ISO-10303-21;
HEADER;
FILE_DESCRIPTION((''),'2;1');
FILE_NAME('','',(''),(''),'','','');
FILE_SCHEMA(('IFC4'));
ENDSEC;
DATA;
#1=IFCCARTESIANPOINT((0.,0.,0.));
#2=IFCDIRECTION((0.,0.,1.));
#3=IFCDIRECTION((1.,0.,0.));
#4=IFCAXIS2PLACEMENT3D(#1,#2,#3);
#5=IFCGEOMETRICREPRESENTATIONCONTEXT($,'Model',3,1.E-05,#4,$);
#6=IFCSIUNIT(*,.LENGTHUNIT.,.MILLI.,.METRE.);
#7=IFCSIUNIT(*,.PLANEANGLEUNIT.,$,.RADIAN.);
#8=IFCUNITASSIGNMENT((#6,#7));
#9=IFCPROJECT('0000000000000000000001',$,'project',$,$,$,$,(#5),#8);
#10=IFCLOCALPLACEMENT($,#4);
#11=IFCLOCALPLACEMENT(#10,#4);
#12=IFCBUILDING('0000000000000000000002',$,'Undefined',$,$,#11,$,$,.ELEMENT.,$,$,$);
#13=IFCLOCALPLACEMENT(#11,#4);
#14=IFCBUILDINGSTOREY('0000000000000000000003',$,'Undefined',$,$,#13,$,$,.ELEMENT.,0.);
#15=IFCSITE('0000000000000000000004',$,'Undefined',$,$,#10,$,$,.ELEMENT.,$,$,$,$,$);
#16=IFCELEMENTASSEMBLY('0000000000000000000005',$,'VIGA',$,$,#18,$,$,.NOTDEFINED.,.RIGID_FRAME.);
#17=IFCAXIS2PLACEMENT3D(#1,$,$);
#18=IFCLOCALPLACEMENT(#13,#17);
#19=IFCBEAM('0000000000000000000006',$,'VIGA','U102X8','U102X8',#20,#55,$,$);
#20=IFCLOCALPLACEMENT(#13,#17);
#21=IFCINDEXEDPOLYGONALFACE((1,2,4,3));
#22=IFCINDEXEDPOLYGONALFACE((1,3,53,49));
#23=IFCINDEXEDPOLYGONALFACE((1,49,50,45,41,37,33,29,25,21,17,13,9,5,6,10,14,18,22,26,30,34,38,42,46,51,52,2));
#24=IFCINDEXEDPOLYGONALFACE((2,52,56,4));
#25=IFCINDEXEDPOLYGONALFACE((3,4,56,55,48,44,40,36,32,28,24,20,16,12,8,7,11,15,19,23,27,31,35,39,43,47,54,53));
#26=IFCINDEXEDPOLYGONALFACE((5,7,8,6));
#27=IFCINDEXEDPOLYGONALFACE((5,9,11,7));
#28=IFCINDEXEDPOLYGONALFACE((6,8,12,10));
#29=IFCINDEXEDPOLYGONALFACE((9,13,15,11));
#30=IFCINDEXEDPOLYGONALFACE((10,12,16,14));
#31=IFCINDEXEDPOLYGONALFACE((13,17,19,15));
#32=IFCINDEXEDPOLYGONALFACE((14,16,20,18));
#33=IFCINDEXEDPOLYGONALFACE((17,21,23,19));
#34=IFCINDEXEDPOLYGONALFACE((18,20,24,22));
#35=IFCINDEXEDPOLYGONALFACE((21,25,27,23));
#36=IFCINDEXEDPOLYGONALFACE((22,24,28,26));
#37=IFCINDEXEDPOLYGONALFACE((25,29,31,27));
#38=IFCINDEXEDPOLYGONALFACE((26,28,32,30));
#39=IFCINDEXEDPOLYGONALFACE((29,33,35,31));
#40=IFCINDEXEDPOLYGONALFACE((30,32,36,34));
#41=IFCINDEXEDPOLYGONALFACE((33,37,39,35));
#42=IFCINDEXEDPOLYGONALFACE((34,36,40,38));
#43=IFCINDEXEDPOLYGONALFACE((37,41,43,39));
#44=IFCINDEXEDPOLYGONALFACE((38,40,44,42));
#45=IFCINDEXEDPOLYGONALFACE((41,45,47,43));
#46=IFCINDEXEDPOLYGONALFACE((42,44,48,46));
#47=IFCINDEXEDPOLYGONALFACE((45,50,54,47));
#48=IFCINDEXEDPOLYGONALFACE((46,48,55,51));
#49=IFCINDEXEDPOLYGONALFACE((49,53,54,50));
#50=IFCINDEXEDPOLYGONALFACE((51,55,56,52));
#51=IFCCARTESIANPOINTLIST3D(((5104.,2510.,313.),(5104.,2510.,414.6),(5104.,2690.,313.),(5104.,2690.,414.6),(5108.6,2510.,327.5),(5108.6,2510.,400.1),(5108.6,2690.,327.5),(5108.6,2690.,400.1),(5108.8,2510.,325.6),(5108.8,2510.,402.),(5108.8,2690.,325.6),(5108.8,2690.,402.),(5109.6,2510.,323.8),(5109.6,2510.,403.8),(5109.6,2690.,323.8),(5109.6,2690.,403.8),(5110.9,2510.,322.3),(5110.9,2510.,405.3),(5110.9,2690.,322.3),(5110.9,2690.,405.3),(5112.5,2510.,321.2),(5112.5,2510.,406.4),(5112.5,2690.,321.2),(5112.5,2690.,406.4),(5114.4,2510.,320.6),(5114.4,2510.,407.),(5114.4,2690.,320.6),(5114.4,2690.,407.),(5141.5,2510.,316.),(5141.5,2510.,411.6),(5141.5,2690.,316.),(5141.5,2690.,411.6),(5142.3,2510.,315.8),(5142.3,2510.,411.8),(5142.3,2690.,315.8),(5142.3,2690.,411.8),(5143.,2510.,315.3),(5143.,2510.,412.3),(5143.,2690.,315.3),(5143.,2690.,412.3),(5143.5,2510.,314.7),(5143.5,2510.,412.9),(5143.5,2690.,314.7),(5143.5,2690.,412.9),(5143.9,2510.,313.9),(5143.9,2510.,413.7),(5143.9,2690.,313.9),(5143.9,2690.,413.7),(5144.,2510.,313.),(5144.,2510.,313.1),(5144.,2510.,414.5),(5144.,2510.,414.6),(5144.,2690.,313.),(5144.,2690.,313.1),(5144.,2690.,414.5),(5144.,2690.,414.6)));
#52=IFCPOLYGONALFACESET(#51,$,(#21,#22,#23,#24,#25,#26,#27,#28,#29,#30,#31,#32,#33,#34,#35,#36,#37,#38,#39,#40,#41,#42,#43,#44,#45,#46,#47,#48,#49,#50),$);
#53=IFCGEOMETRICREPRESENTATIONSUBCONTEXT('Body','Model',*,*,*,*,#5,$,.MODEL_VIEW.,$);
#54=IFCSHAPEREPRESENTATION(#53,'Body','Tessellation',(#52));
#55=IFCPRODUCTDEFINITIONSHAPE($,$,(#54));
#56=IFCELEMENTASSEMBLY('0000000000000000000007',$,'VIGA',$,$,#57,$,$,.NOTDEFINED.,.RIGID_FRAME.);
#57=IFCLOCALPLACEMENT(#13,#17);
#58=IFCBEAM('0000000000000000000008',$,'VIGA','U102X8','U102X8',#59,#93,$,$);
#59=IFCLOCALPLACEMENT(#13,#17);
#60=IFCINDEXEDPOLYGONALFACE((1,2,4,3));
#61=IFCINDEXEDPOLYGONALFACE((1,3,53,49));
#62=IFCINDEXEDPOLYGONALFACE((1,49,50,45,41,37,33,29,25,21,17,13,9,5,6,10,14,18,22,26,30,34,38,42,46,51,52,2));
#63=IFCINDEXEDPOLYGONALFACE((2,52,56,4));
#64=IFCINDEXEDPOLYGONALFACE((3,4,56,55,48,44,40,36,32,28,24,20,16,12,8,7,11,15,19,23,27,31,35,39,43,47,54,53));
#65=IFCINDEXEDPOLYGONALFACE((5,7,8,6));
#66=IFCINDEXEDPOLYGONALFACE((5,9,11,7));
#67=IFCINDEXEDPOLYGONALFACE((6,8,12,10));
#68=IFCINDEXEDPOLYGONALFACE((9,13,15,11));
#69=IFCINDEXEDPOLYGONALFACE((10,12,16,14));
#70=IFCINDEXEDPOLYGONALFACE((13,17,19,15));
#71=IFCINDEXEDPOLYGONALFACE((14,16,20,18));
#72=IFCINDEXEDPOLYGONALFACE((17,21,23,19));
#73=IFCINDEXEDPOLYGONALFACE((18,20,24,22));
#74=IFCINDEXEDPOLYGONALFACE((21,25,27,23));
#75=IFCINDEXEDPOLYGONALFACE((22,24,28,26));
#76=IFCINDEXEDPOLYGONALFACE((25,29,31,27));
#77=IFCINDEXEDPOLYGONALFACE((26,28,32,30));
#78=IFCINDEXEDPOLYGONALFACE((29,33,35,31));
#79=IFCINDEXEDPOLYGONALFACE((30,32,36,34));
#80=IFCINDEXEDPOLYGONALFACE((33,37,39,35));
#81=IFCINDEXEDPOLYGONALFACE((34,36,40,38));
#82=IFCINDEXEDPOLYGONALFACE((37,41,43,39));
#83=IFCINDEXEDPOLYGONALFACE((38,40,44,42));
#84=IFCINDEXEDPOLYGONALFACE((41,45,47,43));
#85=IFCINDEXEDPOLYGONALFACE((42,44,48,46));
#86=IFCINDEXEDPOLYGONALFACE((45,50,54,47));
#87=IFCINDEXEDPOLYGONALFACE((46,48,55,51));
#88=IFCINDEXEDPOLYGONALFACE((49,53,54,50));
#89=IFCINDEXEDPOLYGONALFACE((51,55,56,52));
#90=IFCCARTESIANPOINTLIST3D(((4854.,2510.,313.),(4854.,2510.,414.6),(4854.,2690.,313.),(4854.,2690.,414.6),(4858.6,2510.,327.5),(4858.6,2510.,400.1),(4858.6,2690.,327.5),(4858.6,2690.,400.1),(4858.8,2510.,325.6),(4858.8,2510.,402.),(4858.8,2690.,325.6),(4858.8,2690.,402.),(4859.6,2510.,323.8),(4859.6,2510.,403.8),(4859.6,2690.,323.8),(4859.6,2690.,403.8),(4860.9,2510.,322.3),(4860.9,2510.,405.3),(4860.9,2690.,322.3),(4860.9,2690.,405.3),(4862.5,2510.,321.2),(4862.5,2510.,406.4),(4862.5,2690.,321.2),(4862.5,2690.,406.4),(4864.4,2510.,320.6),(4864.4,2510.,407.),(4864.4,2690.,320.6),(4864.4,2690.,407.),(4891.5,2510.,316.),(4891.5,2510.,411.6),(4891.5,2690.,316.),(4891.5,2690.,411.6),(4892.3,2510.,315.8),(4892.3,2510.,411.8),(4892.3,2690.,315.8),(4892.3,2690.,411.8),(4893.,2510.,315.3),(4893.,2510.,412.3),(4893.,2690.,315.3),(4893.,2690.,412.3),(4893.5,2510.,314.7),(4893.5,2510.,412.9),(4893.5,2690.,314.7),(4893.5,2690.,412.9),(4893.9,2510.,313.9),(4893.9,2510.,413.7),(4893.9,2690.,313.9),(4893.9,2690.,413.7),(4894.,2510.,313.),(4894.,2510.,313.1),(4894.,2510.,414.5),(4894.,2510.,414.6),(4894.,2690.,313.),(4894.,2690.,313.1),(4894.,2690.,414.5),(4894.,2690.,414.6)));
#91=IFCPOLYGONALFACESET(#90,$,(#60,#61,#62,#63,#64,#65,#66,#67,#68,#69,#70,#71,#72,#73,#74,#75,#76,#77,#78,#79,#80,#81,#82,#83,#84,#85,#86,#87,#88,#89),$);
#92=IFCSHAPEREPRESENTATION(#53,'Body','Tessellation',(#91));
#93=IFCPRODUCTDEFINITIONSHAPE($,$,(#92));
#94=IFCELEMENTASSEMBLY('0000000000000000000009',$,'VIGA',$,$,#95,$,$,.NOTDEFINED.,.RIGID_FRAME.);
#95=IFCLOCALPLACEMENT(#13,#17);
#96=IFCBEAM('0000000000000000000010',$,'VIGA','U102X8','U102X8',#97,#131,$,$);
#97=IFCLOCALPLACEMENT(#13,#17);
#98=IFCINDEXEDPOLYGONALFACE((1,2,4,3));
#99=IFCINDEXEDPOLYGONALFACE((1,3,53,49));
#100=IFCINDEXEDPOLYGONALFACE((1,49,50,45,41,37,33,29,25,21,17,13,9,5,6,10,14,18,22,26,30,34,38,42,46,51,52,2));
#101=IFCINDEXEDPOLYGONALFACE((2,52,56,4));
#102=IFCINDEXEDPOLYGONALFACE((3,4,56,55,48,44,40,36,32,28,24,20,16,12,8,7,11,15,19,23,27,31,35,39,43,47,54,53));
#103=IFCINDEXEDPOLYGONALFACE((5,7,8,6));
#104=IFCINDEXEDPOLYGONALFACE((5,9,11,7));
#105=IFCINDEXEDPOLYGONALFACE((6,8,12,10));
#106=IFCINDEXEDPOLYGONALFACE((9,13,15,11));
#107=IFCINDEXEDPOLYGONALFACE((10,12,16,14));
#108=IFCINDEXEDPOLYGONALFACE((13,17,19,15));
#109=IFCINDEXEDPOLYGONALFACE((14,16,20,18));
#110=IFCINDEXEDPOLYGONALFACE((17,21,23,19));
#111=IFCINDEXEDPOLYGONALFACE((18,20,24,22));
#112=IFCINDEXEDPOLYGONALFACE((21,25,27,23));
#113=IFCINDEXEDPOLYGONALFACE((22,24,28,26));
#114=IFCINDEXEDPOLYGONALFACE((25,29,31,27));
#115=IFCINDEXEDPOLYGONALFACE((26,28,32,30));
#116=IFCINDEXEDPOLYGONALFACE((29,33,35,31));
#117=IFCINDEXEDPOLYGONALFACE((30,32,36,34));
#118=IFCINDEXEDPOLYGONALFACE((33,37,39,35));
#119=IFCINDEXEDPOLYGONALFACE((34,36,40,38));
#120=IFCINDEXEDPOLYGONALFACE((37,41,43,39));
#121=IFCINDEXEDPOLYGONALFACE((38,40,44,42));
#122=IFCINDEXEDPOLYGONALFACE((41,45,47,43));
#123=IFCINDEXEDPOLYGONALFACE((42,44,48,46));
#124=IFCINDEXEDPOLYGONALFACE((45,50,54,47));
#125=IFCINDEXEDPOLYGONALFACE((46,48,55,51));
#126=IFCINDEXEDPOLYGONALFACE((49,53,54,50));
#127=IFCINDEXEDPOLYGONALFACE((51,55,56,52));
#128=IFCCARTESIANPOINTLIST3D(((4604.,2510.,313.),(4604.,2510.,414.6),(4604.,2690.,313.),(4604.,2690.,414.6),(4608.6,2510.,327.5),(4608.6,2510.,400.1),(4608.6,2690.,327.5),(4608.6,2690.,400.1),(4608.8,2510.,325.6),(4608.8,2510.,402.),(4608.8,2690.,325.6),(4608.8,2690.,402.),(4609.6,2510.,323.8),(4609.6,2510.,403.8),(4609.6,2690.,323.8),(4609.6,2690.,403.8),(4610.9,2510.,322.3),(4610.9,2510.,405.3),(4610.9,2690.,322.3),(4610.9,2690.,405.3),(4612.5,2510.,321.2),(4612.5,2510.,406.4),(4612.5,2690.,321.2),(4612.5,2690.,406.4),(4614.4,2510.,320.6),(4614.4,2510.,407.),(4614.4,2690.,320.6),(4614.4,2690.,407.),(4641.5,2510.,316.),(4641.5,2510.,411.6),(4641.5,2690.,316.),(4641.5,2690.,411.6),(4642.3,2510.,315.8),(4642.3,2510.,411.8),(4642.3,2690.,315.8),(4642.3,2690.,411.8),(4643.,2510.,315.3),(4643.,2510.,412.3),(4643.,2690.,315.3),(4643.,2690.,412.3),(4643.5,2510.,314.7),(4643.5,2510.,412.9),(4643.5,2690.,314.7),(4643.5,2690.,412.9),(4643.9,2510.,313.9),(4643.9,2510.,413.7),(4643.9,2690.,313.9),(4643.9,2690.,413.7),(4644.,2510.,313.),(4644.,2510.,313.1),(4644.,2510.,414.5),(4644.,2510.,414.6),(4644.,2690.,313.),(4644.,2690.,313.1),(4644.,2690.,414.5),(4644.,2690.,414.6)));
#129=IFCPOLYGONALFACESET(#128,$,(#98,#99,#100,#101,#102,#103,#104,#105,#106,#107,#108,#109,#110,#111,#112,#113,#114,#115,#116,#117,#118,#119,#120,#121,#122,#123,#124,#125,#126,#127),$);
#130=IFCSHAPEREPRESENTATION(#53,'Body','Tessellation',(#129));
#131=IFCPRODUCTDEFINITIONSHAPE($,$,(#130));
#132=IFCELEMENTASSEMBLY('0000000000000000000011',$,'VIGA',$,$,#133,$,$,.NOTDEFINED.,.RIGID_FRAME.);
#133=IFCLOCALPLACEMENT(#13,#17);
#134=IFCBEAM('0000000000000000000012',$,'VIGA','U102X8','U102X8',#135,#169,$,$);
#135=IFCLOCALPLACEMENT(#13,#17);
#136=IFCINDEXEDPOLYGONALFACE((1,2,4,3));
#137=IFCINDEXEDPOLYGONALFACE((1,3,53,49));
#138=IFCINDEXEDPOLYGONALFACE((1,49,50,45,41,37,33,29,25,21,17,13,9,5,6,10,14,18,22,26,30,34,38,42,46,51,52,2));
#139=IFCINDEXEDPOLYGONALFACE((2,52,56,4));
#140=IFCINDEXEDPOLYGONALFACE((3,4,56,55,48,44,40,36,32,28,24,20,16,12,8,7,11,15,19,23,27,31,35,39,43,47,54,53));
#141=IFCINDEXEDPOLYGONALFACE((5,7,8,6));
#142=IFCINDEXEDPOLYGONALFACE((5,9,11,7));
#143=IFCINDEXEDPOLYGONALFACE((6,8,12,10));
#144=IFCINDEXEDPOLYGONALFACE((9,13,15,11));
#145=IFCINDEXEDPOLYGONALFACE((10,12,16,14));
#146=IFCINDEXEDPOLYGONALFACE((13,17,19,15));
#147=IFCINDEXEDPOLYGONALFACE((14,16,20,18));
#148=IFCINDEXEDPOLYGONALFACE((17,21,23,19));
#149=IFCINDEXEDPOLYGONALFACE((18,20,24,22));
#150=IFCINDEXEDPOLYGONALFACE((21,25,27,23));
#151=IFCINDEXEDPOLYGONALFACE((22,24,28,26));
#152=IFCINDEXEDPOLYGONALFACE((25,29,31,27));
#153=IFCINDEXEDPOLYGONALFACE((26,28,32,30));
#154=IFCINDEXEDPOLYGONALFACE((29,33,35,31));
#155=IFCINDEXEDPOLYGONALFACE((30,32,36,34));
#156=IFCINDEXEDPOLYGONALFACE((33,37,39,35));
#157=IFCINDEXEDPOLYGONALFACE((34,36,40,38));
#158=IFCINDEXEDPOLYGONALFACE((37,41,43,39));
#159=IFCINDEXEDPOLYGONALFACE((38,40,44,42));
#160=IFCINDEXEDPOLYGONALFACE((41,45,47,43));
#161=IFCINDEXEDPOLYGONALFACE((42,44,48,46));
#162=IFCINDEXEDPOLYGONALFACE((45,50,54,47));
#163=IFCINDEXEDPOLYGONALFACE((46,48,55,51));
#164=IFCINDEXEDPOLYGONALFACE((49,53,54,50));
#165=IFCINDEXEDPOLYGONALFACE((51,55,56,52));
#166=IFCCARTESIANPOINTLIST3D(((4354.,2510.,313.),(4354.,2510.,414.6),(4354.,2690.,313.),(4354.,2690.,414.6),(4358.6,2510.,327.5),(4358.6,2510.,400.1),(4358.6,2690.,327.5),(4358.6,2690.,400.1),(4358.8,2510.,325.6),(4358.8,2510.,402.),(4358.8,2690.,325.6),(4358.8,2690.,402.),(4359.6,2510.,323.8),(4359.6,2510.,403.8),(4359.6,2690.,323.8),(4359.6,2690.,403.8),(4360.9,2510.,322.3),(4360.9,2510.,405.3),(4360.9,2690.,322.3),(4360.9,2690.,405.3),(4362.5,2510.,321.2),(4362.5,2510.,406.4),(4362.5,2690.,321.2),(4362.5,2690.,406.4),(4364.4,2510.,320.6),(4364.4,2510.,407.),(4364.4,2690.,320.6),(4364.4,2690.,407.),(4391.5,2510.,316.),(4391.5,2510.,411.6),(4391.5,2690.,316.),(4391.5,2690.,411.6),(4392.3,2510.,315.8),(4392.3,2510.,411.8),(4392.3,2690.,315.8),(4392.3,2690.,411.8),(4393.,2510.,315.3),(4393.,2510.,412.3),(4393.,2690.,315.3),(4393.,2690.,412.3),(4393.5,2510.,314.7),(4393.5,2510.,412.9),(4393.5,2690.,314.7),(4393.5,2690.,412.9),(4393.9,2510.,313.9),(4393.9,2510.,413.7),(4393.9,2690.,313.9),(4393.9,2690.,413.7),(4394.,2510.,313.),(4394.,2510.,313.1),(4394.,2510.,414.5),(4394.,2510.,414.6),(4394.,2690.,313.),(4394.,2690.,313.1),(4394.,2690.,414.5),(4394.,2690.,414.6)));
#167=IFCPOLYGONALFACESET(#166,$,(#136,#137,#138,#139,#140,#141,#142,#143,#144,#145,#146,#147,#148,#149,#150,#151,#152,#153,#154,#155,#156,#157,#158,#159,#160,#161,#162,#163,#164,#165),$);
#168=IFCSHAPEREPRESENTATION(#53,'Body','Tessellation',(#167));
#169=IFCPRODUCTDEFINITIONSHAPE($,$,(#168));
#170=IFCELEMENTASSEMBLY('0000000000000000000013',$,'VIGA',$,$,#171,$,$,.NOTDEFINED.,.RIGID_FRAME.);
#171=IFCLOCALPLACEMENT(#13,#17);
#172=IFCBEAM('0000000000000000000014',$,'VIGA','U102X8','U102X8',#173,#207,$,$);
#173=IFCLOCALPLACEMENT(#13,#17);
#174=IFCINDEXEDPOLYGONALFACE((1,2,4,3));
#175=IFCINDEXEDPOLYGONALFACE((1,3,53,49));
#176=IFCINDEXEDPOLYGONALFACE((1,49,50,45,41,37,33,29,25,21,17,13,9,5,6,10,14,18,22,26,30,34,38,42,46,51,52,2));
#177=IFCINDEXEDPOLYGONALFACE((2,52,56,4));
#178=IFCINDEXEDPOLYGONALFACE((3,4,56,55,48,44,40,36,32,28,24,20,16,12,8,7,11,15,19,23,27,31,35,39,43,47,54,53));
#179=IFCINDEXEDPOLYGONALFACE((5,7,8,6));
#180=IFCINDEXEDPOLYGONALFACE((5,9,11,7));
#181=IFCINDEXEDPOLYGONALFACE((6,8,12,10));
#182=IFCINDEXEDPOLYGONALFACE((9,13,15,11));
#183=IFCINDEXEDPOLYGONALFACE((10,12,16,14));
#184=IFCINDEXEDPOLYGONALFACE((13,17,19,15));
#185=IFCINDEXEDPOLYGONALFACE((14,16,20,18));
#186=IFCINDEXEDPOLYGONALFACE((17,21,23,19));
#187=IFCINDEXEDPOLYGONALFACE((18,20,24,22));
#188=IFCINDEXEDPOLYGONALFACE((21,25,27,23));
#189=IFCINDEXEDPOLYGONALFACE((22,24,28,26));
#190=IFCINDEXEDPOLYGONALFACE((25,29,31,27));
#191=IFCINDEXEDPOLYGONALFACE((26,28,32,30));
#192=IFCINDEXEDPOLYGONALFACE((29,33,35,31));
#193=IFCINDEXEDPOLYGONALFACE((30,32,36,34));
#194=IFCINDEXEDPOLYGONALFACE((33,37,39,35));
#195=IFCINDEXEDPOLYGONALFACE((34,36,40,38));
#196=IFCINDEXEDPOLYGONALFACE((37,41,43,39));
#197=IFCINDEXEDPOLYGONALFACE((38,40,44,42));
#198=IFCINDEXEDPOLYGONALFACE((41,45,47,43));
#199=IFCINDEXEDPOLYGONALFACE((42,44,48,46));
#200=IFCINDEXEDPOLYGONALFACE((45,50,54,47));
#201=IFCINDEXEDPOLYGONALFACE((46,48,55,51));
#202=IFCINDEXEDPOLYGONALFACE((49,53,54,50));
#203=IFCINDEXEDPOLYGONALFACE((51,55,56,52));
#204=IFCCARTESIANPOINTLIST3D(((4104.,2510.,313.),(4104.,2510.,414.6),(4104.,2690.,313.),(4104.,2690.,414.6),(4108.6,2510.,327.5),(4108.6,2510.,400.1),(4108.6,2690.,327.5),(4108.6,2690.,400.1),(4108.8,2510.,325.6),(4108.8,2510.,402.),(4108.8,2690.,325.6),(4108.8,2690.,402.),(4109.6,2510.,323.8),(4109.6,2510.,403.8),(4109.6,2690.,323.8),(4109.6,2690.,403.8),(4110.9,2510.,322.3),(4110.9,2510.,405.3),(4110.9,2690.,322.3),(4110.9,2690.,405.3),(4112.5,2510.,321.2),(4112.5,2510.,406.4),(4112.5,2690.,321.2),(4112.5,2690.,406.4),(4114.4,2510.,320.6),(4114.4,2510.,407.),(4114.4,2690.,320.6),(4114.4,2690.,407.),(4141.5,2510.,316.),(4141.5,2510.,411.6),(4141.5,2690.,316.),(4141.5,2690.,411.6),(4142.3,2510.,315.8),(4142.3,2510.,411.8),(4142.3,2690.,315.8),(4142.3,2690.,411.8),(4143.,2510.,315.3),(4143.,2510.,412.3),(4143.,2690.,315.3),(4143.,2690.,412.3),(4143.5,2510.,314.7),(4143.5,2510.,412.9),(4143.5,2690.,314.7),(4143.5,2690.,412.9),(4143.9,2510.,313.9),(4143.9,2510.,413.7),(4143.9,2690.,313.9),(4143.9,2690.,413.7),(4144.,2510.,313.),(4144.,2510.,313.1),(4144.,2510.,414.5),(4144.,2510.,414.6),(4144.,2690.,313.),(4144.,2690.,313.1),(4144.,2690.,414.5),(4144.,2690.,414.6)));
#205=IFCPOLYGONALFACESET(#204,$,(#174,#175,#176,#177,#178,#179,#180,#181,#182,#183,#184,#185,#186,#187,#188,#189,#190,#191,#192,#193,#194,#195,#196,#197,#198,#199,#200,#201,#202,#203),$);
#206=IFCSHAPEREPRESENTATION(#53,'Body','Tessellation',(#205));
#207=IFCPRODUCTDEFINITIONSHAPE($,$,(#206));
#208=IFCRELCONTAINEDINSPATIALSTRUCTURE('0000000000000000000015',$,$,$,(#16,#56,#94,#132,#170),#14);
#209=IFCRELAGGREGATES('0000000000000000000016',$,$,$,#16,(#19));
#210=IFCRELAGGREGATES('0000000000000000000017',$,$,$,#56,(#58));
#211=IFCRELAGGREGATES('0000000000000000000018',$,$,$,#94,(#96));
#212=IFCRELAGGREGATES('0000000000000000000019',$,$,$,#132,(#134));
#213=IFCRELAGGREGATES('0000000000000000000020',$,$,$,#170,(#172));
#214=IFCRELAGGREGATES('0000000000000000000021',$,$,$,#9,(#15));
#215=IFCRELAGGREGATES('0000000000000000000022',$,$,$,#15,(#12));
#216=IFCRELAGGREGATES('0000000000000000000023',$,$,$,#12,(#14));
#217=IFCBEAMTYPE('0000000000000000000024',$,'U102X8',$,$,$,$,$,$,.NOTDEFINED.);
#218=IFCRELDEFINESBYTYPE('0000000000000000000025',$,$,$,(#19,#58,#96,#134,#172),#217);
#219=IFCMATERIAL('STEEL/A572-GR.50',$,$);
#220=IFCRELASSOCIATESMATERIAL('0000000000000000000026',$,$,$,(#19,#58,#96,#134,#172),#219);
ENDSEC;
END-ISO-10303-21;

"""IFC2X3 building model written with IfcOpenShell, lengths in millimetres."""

from ifc_helpers import new_model, si_unit, frame, origin_with_axes, origin_2d_with_axis, place, context, subcontext, project, spatial, u_section, extrude, material, type_object, element, aggregate, save


model = new_model("IFC2X3")

# Units and contexts
model_context = context("Model", 3, precision=1e-05, world=origin_with_axes())
body_context = subcontext(model_context, "Body", "Model", "MODEL_VIEW")
ifc_project = project(units=[si_unit("LENGTHUNIT", "METRE", prefix="MILLI"), si_unit("PLANEANGLEUNIT", "RADIAN")], contexts=[model_context])

# Site, building, storey
site_placement = place(None, origin_with_axes())
site = spatial("IfcSite", under=ifc_project, at=site_placement, Name="Undefined", CompositionType="ELEMENT")
building_placement = place(site_placement, origin_with_axes())
building = spatial("IfcBuilding", under=site, at=building_placement, Name="Undefined", CompositionType="ELEMENT")
storey_placement = place(building_placement, origin_with_axes())
storey = spatial("IfcBuildingStorey", under=building, at=storey_placement, Name="Undefined", CompositionType="ELEMENT", Elevation=0.0)

# Element assemblies, beams
ifc_material_1 = material(Name="STEEL/A572-GR.50")
beam_type_1 = type_object("IfcBeamType", Name="U102X8", PredefinedType="NOTDEFINED")
assembly_1_placement = place(storey_placement, origin_with_axes())
assembly_1 = element("IfcElementAssembly", 1, at=assembly_1_placement, inside=storey, Name="VIGA", AssemblyPlace="NOTDEFINED", PredefinedType="RIGID_FRAME")
beam_1_placement = place(assembly_1_placement, frame((5124.0, 2510.0, 363.8), z_axis=(0.0, 0.0, 1.0), x_axis=(0.0, 1.0, 0.0)))
beam_1 = element("IfcBeam", 2, at=beam_1_placement, type_object=beam_type_1, material=ifc_material_1, Name="VIGA", Description="U102X8", ObjectType="U102X8", context=body_context, shape_type="SweptSolid", body=[
    extrude(u_section(Depth=101.6, FlangeWidth=40.0, WebThickness=4.6, FlangeThickness=6.0, FilletRadius=7.0, EdgeRadius=3.0, FlangeSlope=0.16839, at=origin_2d_with_axis()), frame((180.0, 0.0, 0.0), z_axis=(-1.0, 0.0, 0.0), x_axis=(0.0, -1.0, 0.0)), (0.0, 0.0, 1.0), 180.0),
])
aggregate(assembly_1, [beam_1])
assembly_2_placement = place(storey_placement, origin_with_axes())
assembly_2 = element("IfcElementAssembly", 3, at=assembly_2_placement, inside=storey, Name="VIGA", AssemblyPlace="NOTDEFINED", PredefinedType="RIGID_FRAME")
beam_2_placement = place(assembly_2_placement, frame((4874.0, 2510.0, 363.8), z_axis=(0.0, 0.0, 1.0), x_axis=(0.0, 1.0, 0.0)))
beam_2 = element("IfcBeam", 4, at=beam_2_placement, type_object=beam_type_1, material=ifc_material_1, Name="VIGA", Description="U102X8", ObjectType="U102X8", context=body_context, shape_type="SweptSolid", body=[
    extrude(u_section(Depth=101.6, FlangeWidth=40.0, WebThickness=4.6, FlangeThickness=6.0, FilletRadius=7.0, EdgeRadius=3.0, FlangeSlope=0.16839, at=origin_2d_with_axis()), frame((180.0, 0.0, 0.0), z_axis=(-1.0, 0.0, 0.0), x_axis=(0.0, -1.0, 0.0)), (0.0, 0.0, 1.0), 180.0),
])
aggregate(assembly_2, [beam_2])
assembly_3_placement = place(storey_placement, origin_with_axes())
assembly_3 = element("IfcElementAssembly", 5, at=assembly_3_placement, inside=storey, Name="VIGA", AssemblyPlace="NOTDEFINED", PredefinedType="RIGID_FRAME")
beam_3_placement = place(assembly_3_placement, frame((4624.0, 2510.0, 363.8), z_axis=(0.0, 0.0, 1.0), x_axis=(0.0, 1.0, 0.0)))
beam_3 = element("IfcBeam", 6, at=beam_3_placement, type_object=beam_type_1, material=ifc_material_1, Name="VIGA", Description="U102X8", ObjectType="U102X8", context=body_context, shape_type="SweptSolid", body=[
    extrude(u_section(Depth=101.6, FlangeWidth=40.0, WebThickness=4.6, FlangeThickness=6.0, FilletRadius=7.0, EdgeRadius=3.0, FlangeSlope=0.16839, at=origin_2d_with_axis()), frame((180.0, 0.0, 0.0), z_axis=(-1.0, 0.0, 0.0), x_axis=(0.0, -1.0, 0.0)), (0.0, 0.0, 1.0), 180.0),
])
aggregate(assembly_3, [beam_3])
assembly_4_placement = place(storey_placement, origin_with_axes())
assembly_4 = element("IfcElementAssembly", 7, at=assembly_4_placement, inside=storey, Name="VIGA", AssemblyPlace="NOTDEFINED", PredefinedType="RIGID_FRAME")
beam_4_placement = place(assembly_4_placement, frame((4374.0, 2510.0, 363.8), z_axis=(0.0, 0.0, 1.0), x_axis=(0.0, 1.0, 0.0)))
beam_4 = element("IfcBeam", 8, at=beam_4_placement, type_object=beam_type_1, material=ifc_material_1, Name="VIGA", Description="U102X8", ObjectType="U102X8", context=body_context, shape_type="SweptSolid", body=[
    extrude(u_section(Depth=101.6, FlangeWidth=40.0, WebThickness=4.6, FlangeThickness=6.0, FilletRadius=7.0, EdgeRadius=3.0, FlangeSlope=0.16839, at=origin_2d_with_axis()), frame((180.0, 0.0, 0.0), z_axis=(-1.0, 0.0, 0.0), x_axis=(0.0, -1.0, 0.0)), (0.0, 0.0, 1.0), 180.0),
])
aggregate(assembly_4, [beam_4])
assembly_5_placement = place(storey_placement, origin_with_axes())
assembly_5 = element("IfcElementAssembly", 9, at=assembly_5_placement, inside=storey, Name="VIGA", AssemblyPlace="NOTDEFINED", PredefinedType="RIGID_FRAME")
beam_5_placement = place(assembly_5_placement, frame((4124.0, 2510.0, 363.8), z_axis=(0.0, 0.0, 1.0), x_axis=(0.0, 1.0, 0.0)))
beam_5 = element("IfcBeam", 10, at=beam_5_placement, type_object=beam_type_1, material=ifc_material_1, Name="VIGA", Description="U102X8", ObjectType="U102X8", context=body_context, shape_type="SweptSolid", body=[
    extrude(u_section(Depth=101.6, FlangeWidth=40.0, WebThickness=4.6, FlangeThickness=6.0, FilletRadius=7.0, EdgeRadius=3.0, FlangeSlope=0.16839, at=origin_2d_with_axis()), frame((180.0, 0.0, 0.0), z_axis=(-1.0, 0.0, 0.0), x_axis=(0.0, -1.0, 0.0)), (0.0, 0.0, 1.0), 180.0),
])
aggregate(assembly_5, [beam_5])

save(model, "model.ifc")
